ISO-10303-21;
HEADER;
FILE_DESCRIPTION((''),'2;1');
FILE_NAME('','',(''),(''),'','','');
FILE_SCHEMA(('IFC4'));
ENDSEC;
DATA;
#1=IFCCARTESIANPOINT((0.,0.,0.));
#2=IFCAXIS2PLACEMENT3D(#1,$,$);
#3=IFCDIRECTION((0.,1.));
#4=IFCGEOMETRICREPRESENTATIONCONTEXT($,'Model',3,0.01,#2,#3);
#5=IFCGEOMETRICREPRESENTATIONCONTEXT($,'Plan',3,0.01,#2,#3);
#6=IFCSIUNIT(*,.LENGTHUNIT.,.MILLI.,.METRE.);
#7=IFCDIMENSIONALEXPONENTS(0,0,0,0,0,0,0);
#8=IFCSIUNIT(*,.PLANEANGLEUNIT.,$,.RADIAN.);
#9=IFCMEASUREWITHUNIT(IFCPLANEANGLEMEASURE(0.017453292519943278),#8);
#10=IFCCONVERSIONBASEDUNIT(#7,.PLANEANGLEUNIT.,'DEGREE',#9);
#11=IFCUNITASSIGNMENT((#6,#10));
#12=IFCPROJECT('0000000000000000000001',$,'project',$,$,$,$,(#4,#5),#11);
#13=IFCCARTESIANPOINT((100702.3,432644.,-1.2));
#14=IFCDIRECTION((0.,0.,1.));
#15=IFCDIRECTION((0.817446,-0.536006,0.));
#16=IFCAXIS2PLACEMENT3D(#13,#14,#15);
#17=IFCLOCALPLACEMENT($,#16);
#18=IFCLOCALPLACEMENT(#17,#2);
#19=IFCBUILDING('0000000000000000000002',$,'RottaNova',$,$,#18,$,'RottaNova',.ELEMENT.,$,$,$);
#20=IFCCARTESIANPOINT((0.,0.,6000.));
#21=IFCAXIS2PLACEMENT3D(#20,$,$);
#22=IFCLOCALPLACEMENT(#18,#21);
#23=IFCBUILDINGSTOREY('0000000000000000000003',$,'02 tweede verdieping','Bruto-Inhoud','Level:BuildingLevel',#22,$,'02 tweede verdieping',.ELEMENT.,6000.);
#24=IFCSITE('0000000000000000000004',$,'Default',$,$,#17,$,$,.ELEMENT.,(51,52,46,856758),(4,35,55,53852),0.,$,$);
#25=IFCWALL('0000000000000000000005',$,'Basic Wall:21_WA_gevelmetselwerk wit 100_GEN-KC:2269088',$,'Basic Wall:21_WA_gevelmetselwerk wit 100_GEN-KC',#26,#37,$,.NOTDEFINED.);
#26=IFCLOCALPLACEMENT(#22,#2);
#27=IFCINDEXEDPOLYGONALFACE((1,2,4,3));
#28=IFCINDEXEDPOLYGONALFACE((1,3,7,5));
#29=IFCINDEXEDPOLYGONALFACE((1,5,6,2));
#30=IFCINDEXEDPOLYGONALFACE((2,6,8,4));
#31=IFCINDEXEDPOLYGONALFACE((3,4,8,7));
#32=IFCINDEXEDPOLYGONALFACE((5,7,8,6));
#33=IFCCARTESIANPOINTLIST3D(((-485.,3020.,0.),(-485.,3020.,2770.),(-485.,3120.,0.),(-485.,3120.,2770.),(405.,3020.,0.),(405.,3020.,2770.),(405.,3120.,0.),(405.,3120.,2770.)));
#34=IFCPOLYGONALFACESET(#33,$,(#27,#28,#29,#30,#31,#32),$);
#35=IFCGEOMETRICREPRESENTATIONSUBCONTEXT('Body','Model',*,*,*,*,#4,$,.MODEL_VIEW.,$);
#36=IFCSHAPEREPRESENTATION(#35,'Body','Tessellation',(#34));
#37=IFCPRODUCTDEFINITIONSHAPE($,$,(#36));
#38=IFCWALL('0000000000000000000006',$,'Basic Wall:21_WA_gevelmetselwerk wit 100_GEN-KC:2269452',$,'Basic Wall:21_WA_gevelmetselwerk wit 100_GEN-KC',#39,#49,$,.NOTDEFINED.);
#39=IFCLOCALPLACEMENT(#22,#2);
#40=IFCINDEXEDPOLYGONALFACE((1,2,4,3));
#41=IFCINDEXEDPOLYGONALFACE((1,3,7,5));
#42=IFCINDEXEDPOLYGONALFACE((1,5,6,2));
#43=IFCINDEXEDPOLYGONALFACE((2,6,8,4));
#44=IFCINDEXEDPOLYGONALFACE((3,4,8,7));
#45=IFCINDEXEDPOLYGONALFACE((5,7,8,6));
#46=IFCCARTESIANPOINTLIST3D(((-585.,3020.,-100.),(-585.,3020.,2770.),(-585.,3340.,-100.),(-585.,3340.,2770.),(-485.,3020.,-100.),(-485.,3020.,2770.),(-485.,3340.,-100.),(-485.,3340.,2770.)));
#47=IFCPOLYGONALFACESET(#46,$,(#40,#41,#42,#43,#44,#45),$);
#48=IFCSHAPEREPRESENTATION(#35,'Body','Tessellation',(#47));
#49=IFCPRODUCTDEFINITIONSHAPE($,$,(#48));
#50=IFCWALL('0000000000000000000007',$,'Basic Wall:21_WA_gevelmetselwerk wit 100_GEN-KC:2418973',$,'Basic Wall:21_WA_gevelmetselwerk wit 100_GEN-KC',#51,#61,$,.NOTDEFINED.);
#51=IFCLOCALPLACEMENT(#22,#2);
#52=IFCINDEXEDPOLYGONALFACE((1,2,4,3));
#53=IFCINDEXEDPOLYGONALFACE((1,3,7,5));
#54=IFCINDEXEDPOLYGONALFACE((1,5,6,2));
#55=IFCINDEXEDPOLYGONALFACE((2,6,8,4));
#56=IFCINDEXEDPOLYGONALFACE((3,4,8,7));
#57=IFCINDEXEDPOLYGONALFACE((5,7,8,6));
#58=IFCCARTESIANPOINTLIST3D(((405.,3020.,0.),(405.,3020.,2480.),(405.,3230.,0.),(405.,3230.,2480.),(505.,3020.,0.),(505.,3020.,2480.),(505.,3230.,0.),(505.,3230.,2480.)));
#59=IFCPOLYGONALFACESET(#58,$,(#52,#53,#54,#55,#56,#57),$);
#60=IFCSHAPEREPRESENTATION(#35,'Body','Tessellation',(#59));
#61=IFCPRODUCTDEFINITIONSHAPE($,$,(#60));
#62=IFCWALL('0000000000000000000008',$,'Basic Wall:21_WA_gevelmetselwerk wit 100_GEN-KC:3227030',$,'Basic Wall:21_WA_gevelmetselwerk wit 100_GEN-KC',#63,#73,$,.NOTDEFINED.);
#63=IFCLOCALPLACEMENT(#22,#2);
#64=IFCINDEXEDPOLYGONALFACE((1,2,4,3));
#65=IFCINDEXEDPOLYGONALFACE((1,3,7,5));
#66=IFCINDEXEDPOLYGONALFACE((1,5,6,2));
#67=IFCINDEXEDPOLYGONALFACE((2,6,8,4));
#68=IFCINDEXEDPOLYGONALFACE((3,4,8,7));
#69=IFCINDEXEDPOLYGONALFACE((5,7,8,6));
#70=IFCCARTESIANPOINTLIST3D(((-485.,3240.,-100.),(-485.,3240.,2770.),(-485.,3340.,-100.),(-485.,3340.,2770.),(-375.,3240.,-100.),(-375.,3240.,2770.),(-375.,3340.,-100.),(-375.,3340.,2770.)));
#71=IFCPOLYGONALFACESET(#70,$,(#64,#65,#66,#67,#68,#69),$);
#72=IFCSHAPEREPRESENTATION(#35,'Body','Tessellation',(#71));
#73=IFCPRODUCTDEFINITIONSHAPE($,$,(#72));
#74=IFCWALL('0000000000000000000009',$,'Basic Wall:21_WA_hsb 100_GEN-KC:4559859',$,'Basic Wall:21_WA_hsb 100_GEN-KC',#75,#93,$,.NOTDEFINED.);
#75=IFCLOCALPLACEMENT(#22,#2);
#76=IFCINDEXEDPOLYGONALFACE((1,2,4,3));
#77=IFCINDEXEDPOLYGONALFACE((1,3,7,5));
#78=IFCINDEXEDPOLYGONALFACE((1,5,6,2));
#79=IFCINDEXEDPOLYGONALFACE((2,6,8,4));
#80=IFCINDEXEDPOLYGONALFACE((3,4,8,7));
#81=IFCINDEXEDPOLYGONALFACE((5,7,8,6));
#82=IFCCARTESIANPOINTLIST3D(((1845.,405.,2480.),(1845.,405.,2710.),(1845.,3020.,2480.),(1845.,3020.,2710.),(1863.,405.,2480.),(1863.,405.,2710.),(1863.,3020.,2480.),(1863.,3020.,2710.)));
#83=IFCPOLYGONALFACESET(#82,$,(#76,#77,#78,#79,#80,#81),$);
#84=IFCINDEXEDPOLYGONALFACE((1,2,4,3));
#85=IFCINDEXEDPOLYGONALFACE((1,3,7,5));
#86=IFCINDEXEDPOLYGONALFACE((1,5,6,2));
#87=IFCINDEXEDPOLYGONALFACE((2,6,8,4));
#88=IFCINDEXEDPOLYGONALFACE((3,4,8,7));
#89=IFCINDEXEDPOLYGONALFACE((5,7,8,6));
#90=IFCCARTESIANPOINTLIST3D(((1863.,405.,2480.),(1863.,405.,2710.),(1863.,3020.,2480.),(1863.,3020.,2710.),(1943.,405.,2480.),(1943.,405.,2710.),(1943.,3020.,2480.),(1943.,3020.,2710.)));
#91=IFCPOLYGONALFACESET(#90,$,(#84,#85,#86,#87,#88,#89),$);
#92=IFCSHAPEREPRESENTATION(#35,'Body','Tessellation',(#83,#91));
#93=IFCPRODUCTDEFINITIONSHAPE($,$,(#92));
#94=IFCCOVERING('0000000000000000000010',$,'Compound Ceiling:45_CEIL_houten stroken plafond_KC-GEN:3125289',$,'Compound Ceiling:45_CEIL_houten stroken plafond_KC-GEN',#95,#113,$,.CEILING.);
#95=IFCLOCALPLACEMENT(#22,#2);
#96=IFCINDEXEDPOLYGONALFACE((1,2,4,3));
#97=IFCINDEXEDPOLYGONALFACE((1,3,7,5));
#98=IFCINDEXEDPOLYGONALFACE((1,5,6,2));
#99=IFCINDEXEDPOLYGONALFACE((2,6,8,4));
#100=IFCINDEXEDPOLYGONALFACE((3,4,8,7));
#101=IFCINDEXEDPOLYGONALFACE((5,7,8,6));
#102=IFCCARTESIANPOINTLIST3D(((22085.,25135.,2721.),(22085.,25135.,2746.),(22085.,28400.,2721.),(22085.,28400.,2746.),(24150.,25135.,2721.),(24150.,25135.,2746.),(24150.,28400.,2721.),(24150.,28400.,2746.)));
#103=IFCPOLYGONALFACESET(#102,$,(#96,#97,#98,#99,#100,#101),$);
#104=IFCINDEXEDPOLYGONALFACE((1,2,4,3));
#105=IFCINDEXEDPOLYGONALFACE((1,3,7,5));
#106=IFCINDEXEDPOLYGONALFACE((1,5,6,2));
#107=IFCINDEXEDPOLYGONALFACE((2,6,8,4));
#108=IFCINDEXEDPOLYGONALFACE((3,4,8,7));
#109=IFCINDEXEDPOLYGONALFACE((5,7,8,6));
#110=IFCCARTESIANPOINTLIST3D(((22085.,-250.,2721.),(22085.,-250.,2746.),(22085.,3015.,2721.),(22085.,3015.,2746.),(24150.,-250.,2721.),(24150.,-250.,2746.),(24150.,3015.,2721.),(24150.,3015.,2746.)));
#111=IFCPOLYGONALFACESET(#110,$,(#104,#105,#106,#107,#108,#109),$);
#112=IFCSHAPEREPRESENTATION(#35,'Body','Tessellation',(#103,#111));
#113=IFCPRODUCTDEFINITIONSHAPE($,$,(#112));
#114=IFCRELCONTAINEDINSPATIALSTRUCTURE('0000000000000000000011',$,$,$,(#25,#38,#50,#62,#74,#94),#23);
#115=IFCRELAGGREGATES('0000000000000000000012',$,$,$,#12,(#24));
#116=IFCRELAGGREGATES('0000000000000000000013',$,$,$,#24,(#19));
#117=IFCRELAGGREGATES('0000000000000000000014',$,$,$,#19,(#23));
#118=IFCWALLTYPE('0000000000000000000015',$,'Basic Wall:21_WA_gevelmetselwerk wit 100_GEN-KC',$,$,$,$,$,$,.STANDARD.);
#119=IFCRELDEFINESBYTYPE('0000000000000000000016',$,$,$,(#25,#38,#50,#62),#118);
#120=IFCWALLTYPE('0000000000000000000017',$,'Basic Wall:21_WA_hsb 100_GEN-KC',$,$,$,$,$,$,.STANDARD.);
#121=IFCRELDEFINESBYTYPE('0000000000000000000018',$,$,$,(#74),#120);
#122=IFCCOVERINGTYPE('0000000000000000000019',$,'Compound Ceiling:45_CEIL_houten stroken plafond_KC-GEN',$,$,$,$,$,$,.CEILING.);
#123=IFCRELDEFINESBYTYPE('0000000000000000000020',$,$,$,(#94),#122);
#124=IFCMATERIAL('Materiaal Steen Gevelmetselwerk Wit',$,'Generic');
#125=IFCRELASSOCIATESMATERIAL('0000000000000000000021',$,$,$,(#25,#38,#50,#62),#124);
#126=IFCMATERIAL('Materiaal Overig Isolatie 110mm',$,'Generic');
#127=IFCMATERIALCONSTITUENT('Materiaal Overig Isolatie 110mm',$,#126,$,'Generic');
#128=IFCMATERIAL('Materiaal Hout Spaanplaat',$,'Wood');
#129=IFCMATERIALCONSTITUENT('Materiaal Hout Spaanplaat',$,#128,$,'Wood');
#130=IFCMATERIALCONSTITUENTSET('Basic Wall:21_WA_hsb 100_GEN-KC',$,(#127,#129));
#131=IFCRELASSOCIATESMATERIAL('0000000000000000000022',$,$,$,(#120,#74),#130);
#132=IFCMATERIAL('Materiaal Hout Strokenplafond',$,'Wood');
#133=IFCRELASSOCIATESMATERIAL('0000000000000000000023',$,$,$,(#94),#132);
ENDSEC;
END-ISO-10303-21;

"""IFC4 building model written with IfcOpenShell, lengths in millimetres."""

from ifc_helpers import new_model, entity, si_unit, converted_unit, direction, frame, origin, place, context, subcontext, project, spatial, indexed_curve, outline, extrude, material, constituent, constituent_set, type_object, element, save


model = new_model("IFC4")

# Units and contexts
model_context = context("Model", 3, precision=0.01, world=origin(), true_north=direction((0.0, 1.0)))
plan_context = context("Plan", 3, precision=0.01, world=origin(), true_north=direction((0.0, 1.0)))
body_context = subcontext(model_context, "Body", "Model", "MODEL_VIEW")
ifc_project = project(units=[si_unit("LENGTHUNIT", "METRE", prefix="MILLI"), converted_unit("PLANEANGLEUNIT", "DEGREE", entity("IfcPlaneAngleMeasure", 0.017453292519943278), si_unit("PLANEANGLEUNIT", "RADIAN"), dimensions=[0, 0, 0, 0, 0, 0, 0])], contexts=[model_context, plan_context])

# Site, building, storey
site_placement = place(None, frame((100702.3, 432644.0, -1.2), z_axis=(0.0, 0.0, 1.0), x_axis=(0.817446, -0.536006, 0.0)))
site = spatial("IfcSite", under=ifc_project, at=site_placement, Name="Default", CompositionType="ELEMENT", RefLatitude=(51, 52, 46, 856758), RefLongitude=(4, 35, 55, 53852), RefElevation=0.0)
building_placement = place(site_placement, origin())
building = spatial("IfcBuilding", under=site, at=building_placement, Name="RottaNova", LongName="RottaNova", CompositionType="ELEMENT")
storey_placement = place(building_placement, frame((0.0, 0.0, 6000.0)))
storey = spatial("IfcBuildingStorey", under=building, at=storey_placement, Name="02 tweede verdieping", Description="Bruto-Inhoud", ObjectType="Level:BuildingLevel", LongName="02 tweede verdieping", CompositionType="ELEMENT", Elevation=6000.0)

# Walls
ifc_material_1 = material(Name="Materiaal Steen Gevelmetselwerk Wit", Category="Generic")
wall_type_1 = type_object("IfcWallType", Name="Basic Wall:21_WA_gevelmetselwerk wit 100_GEN-KC", PredefinedType="STANDARD")
wall_1_placement = place(storey_placement, frame((-485.0, 3070.0, 0.0)))
element("IfcWall", 1, at=wall_1_placement, inside=storey, type_object=wall_type_1, material=ifc_material_1, Name="Basic Wall:21_WA_gevelmetselwerk wit 100_GEN-KC:2269088", ObjectType="Basic Wall:21_WA_gevelmetselwerk wit 100_GEN-KC", PredefinedType="NOTDEFINED", context=body_context, shape_type="SweptSolid", body=[
    extrude(outline(indexed_curve([(890.0, 50.0), (0.0, 50.0), (0.0, -50.0), (890.0, -50.0), (890.0, 50.0)], self_intersect=False)), origin(), (0.0, 0.0, 1.0), 2770.0),
])
wall_2_placement = place(storey_placement, frame((-535.0, 3340.0, -100.0), z_axis=(0.0, 0.0, 1.0), x_axis=(0.0, -1.0, 0.0)))
element("IfcWall", 2, at=wall_2_placement, inside=storey, type_object=wall_type_1, material=ifc_material_1, Name="Basic Wall:21_WA_gevelmetselwerk wit 100_GEN-KC:2269452", ObjectType="Basic Wall:21_WA_gevelmetselwerk wit 100_GEN-KC", PredefinedType="NOTDEFINED", context=body_context, shape_type="SweptSolid", body=[
    extrude(outline(indexed_curve([(320.0, 50.0), (0.0, 50.0), (0.0, -50.0), (320.0, -50.0), (320.0, 50.0)], self_intersect=False)), origin(), (0.0, 0.0, 1.0), 2870.0),
])
wall_3_placement = place(storey_placement, frame((455.0, 3230.0, 0.0), z_axis=(0.0, 0.0, 1.0), x_axis=(0.0, -1.0, 0.0)))
element("IfcWall", 3, at=wall_3_placement, inside=storey, type_object=wall_type_1, material=ifc_material_1, Name="Basic Wall:21_WA_gevelmetselwerk wit 100_GEN-KC:2418973", ObjectType="Basic Wall:21_WA_gevelmetselwerk wit 100_GEN-KC", PredefinedType="NOTDEFINED", context=body_context, shape_type="SweptSolid", body=[
    extrude(outline(indexed_curve([(210.0, 50.0), (0.0, 50.0), (0.0, -50.0), (210.0, -50.0), (210.0, 50.0)], self_intersect=False)), origin(), (0.0, 0.0, 1.0), 2480.0),
])
wall_4_placement = place(storey_placement, frame((-485.0, 3290.0, -100.0)))
element("IfcWall", 4, at=wall_4_placement, inside=storey, type_object=wall_type_1, material=ifc_material_1, Name="Basic Wall:21_WA_gevelmetselwerk wit 100_GEN-KC:3227030", ObjectType="Basic Wall:21_WA_gevelmetselwerk wit 100_GEN-KC", PredefinedType="NOTDEFINED", context=body_context, shape_type="SweptSolid", body=[
    extrude(outline(indexed_curve([(110.0, 50.0), (0.0, 50.0), (0.0, -50.0), (110.0, -50.0), (110.0, 50.0)], self_intersect=False)), origin(), (0.0, 0.0, 1.0), 2870.0),
])
ifc_material_2 = material(Name="Materiaal Overig Isolatie 110mm", Category="Generic")
ifc_constituent_1 = constituent(ifc_material_2, Name="Materiaal Overig Isolatie 110mm", Category="Generic")
ifc_material_3 = material(Name="Materiaal Hout Spaanplaat", Category="Wood")
ifc_constituent_2 = constituent(ifc_material_3, Name="Materiaal Hout Spaanplaat", Category="Wood")
ifc_constituent_set = constituent_set(constituents=[ifc_constituent_1, ifc_constituent_2], Name="Basic Wall:21_WA_hsb 100_GEN-KC")
wall_type_2 = type_object("IfcWallType", Name="Basic Wall:21_WA_hsb 100_GEN-KC", PredefinedType="STANDARD", material=ifc_constituent_set)
wall_5_placement = place(storey_placement, frame((1894.0, 3020.0, 2480.0), z_axis=(0.0, 0.0, 1.0), x_axis=(0.0, -1.0, 0.0)))
element("IfcWall", 5, at=wall_5_placement, inside=storey, type_object=wall_type_2, material=ifc_constituent_set, Name="Basic Wall:21_WA_hsb 100_GEN-KC:4559859", ObjectType="Basic Wall:21_WA_hsb 100_GEN-KC", PredefinedType="NOTDEFINED", context=body_context, shape_type="SweptSolid", body=[
    extrude(outline(indexed_curve([(-9.0, -1307.5), (9.0, -1307.5), (9.0, 1307.5), (-9.0, 1307.5), (-9.0, -1307.5)], self_intersect=False)), frame((1307.5, -40.0, 0.0), z_axis=(0.0, 0.0, 1.0), x_axis=(0.0, 1.0, 0.0)), (0.0, 0.0, 1.0), 230.0),
    extrude(outline(indexed_curve([(-40.0, -1307.5), (40.0, -1307.5), (40.0, 1307.5), (-40.0, 1307.5), (-40.0, -1307.5)], self_intersect=False)), frame((1307.5, 9.0, 0.0), z_axis=(0.0, 0.0, 1.0), x_axis=(0.0, -1.0, 0.0)), (0.0, 0.0, 1.0), 230.0),
])

# Covering
ifc_material_4 = material(Name="Materiaal Hout Strokenplafond", Category="Wood")
covering_type_1 = type_object("IfcCoveringType", Name="Compound Ceiling:45_CEIL_houten stroken plafond_KC-GEN", PredefinedType="CEILING")
covering_1_placement = place(storey_placement, origin())
element("IfcCovering", 6, at=covering_1_placement, inside=storey, type_object=covering_type_1, material=ifc_material_4, Name="Compound Ceiling:45_CEIL_houten stroken plafond_KC-GEN:3125289", ObjectType="Compound Ceiling:45_CEIL_houten stroken plafond_KC-GEN", PredefinedType="CEILING", context=body_context, shape_type="SweptSolid", body=[
    extrude(outline(indexed_curve([(-1032.5, -1632.5), (1032.5, -1632.5), (1032.5, 1632.5), (-1032.5, 1632.5), (-1032.5, -1632.5)], self_intersect=False)), frame((23117.5, 26767.5, 2721.0), z_axis=(0.0, 0.0, 1.0), x_axis=(-1.0, 0.0, 0.0)), (0.0, 0.0, 1.0), 25.0),
    extrude(outline(indexed_curve([(-1032.5, -1632.5), (1032.5, -1632.5), (1032.5, 1632.5), (-1032.5, 1632.5), (-1032.5, -1632.5)], self_intersect=False)), frame((23117.5, 1382.5, 2721.0), z_axis=(0.0, 0.0, 1.0), x_axis=(-1.0, 0.0, 0.0)), (0.0, 0.0, 1.0), 25.0),
])

save(model, "model.ifc")
